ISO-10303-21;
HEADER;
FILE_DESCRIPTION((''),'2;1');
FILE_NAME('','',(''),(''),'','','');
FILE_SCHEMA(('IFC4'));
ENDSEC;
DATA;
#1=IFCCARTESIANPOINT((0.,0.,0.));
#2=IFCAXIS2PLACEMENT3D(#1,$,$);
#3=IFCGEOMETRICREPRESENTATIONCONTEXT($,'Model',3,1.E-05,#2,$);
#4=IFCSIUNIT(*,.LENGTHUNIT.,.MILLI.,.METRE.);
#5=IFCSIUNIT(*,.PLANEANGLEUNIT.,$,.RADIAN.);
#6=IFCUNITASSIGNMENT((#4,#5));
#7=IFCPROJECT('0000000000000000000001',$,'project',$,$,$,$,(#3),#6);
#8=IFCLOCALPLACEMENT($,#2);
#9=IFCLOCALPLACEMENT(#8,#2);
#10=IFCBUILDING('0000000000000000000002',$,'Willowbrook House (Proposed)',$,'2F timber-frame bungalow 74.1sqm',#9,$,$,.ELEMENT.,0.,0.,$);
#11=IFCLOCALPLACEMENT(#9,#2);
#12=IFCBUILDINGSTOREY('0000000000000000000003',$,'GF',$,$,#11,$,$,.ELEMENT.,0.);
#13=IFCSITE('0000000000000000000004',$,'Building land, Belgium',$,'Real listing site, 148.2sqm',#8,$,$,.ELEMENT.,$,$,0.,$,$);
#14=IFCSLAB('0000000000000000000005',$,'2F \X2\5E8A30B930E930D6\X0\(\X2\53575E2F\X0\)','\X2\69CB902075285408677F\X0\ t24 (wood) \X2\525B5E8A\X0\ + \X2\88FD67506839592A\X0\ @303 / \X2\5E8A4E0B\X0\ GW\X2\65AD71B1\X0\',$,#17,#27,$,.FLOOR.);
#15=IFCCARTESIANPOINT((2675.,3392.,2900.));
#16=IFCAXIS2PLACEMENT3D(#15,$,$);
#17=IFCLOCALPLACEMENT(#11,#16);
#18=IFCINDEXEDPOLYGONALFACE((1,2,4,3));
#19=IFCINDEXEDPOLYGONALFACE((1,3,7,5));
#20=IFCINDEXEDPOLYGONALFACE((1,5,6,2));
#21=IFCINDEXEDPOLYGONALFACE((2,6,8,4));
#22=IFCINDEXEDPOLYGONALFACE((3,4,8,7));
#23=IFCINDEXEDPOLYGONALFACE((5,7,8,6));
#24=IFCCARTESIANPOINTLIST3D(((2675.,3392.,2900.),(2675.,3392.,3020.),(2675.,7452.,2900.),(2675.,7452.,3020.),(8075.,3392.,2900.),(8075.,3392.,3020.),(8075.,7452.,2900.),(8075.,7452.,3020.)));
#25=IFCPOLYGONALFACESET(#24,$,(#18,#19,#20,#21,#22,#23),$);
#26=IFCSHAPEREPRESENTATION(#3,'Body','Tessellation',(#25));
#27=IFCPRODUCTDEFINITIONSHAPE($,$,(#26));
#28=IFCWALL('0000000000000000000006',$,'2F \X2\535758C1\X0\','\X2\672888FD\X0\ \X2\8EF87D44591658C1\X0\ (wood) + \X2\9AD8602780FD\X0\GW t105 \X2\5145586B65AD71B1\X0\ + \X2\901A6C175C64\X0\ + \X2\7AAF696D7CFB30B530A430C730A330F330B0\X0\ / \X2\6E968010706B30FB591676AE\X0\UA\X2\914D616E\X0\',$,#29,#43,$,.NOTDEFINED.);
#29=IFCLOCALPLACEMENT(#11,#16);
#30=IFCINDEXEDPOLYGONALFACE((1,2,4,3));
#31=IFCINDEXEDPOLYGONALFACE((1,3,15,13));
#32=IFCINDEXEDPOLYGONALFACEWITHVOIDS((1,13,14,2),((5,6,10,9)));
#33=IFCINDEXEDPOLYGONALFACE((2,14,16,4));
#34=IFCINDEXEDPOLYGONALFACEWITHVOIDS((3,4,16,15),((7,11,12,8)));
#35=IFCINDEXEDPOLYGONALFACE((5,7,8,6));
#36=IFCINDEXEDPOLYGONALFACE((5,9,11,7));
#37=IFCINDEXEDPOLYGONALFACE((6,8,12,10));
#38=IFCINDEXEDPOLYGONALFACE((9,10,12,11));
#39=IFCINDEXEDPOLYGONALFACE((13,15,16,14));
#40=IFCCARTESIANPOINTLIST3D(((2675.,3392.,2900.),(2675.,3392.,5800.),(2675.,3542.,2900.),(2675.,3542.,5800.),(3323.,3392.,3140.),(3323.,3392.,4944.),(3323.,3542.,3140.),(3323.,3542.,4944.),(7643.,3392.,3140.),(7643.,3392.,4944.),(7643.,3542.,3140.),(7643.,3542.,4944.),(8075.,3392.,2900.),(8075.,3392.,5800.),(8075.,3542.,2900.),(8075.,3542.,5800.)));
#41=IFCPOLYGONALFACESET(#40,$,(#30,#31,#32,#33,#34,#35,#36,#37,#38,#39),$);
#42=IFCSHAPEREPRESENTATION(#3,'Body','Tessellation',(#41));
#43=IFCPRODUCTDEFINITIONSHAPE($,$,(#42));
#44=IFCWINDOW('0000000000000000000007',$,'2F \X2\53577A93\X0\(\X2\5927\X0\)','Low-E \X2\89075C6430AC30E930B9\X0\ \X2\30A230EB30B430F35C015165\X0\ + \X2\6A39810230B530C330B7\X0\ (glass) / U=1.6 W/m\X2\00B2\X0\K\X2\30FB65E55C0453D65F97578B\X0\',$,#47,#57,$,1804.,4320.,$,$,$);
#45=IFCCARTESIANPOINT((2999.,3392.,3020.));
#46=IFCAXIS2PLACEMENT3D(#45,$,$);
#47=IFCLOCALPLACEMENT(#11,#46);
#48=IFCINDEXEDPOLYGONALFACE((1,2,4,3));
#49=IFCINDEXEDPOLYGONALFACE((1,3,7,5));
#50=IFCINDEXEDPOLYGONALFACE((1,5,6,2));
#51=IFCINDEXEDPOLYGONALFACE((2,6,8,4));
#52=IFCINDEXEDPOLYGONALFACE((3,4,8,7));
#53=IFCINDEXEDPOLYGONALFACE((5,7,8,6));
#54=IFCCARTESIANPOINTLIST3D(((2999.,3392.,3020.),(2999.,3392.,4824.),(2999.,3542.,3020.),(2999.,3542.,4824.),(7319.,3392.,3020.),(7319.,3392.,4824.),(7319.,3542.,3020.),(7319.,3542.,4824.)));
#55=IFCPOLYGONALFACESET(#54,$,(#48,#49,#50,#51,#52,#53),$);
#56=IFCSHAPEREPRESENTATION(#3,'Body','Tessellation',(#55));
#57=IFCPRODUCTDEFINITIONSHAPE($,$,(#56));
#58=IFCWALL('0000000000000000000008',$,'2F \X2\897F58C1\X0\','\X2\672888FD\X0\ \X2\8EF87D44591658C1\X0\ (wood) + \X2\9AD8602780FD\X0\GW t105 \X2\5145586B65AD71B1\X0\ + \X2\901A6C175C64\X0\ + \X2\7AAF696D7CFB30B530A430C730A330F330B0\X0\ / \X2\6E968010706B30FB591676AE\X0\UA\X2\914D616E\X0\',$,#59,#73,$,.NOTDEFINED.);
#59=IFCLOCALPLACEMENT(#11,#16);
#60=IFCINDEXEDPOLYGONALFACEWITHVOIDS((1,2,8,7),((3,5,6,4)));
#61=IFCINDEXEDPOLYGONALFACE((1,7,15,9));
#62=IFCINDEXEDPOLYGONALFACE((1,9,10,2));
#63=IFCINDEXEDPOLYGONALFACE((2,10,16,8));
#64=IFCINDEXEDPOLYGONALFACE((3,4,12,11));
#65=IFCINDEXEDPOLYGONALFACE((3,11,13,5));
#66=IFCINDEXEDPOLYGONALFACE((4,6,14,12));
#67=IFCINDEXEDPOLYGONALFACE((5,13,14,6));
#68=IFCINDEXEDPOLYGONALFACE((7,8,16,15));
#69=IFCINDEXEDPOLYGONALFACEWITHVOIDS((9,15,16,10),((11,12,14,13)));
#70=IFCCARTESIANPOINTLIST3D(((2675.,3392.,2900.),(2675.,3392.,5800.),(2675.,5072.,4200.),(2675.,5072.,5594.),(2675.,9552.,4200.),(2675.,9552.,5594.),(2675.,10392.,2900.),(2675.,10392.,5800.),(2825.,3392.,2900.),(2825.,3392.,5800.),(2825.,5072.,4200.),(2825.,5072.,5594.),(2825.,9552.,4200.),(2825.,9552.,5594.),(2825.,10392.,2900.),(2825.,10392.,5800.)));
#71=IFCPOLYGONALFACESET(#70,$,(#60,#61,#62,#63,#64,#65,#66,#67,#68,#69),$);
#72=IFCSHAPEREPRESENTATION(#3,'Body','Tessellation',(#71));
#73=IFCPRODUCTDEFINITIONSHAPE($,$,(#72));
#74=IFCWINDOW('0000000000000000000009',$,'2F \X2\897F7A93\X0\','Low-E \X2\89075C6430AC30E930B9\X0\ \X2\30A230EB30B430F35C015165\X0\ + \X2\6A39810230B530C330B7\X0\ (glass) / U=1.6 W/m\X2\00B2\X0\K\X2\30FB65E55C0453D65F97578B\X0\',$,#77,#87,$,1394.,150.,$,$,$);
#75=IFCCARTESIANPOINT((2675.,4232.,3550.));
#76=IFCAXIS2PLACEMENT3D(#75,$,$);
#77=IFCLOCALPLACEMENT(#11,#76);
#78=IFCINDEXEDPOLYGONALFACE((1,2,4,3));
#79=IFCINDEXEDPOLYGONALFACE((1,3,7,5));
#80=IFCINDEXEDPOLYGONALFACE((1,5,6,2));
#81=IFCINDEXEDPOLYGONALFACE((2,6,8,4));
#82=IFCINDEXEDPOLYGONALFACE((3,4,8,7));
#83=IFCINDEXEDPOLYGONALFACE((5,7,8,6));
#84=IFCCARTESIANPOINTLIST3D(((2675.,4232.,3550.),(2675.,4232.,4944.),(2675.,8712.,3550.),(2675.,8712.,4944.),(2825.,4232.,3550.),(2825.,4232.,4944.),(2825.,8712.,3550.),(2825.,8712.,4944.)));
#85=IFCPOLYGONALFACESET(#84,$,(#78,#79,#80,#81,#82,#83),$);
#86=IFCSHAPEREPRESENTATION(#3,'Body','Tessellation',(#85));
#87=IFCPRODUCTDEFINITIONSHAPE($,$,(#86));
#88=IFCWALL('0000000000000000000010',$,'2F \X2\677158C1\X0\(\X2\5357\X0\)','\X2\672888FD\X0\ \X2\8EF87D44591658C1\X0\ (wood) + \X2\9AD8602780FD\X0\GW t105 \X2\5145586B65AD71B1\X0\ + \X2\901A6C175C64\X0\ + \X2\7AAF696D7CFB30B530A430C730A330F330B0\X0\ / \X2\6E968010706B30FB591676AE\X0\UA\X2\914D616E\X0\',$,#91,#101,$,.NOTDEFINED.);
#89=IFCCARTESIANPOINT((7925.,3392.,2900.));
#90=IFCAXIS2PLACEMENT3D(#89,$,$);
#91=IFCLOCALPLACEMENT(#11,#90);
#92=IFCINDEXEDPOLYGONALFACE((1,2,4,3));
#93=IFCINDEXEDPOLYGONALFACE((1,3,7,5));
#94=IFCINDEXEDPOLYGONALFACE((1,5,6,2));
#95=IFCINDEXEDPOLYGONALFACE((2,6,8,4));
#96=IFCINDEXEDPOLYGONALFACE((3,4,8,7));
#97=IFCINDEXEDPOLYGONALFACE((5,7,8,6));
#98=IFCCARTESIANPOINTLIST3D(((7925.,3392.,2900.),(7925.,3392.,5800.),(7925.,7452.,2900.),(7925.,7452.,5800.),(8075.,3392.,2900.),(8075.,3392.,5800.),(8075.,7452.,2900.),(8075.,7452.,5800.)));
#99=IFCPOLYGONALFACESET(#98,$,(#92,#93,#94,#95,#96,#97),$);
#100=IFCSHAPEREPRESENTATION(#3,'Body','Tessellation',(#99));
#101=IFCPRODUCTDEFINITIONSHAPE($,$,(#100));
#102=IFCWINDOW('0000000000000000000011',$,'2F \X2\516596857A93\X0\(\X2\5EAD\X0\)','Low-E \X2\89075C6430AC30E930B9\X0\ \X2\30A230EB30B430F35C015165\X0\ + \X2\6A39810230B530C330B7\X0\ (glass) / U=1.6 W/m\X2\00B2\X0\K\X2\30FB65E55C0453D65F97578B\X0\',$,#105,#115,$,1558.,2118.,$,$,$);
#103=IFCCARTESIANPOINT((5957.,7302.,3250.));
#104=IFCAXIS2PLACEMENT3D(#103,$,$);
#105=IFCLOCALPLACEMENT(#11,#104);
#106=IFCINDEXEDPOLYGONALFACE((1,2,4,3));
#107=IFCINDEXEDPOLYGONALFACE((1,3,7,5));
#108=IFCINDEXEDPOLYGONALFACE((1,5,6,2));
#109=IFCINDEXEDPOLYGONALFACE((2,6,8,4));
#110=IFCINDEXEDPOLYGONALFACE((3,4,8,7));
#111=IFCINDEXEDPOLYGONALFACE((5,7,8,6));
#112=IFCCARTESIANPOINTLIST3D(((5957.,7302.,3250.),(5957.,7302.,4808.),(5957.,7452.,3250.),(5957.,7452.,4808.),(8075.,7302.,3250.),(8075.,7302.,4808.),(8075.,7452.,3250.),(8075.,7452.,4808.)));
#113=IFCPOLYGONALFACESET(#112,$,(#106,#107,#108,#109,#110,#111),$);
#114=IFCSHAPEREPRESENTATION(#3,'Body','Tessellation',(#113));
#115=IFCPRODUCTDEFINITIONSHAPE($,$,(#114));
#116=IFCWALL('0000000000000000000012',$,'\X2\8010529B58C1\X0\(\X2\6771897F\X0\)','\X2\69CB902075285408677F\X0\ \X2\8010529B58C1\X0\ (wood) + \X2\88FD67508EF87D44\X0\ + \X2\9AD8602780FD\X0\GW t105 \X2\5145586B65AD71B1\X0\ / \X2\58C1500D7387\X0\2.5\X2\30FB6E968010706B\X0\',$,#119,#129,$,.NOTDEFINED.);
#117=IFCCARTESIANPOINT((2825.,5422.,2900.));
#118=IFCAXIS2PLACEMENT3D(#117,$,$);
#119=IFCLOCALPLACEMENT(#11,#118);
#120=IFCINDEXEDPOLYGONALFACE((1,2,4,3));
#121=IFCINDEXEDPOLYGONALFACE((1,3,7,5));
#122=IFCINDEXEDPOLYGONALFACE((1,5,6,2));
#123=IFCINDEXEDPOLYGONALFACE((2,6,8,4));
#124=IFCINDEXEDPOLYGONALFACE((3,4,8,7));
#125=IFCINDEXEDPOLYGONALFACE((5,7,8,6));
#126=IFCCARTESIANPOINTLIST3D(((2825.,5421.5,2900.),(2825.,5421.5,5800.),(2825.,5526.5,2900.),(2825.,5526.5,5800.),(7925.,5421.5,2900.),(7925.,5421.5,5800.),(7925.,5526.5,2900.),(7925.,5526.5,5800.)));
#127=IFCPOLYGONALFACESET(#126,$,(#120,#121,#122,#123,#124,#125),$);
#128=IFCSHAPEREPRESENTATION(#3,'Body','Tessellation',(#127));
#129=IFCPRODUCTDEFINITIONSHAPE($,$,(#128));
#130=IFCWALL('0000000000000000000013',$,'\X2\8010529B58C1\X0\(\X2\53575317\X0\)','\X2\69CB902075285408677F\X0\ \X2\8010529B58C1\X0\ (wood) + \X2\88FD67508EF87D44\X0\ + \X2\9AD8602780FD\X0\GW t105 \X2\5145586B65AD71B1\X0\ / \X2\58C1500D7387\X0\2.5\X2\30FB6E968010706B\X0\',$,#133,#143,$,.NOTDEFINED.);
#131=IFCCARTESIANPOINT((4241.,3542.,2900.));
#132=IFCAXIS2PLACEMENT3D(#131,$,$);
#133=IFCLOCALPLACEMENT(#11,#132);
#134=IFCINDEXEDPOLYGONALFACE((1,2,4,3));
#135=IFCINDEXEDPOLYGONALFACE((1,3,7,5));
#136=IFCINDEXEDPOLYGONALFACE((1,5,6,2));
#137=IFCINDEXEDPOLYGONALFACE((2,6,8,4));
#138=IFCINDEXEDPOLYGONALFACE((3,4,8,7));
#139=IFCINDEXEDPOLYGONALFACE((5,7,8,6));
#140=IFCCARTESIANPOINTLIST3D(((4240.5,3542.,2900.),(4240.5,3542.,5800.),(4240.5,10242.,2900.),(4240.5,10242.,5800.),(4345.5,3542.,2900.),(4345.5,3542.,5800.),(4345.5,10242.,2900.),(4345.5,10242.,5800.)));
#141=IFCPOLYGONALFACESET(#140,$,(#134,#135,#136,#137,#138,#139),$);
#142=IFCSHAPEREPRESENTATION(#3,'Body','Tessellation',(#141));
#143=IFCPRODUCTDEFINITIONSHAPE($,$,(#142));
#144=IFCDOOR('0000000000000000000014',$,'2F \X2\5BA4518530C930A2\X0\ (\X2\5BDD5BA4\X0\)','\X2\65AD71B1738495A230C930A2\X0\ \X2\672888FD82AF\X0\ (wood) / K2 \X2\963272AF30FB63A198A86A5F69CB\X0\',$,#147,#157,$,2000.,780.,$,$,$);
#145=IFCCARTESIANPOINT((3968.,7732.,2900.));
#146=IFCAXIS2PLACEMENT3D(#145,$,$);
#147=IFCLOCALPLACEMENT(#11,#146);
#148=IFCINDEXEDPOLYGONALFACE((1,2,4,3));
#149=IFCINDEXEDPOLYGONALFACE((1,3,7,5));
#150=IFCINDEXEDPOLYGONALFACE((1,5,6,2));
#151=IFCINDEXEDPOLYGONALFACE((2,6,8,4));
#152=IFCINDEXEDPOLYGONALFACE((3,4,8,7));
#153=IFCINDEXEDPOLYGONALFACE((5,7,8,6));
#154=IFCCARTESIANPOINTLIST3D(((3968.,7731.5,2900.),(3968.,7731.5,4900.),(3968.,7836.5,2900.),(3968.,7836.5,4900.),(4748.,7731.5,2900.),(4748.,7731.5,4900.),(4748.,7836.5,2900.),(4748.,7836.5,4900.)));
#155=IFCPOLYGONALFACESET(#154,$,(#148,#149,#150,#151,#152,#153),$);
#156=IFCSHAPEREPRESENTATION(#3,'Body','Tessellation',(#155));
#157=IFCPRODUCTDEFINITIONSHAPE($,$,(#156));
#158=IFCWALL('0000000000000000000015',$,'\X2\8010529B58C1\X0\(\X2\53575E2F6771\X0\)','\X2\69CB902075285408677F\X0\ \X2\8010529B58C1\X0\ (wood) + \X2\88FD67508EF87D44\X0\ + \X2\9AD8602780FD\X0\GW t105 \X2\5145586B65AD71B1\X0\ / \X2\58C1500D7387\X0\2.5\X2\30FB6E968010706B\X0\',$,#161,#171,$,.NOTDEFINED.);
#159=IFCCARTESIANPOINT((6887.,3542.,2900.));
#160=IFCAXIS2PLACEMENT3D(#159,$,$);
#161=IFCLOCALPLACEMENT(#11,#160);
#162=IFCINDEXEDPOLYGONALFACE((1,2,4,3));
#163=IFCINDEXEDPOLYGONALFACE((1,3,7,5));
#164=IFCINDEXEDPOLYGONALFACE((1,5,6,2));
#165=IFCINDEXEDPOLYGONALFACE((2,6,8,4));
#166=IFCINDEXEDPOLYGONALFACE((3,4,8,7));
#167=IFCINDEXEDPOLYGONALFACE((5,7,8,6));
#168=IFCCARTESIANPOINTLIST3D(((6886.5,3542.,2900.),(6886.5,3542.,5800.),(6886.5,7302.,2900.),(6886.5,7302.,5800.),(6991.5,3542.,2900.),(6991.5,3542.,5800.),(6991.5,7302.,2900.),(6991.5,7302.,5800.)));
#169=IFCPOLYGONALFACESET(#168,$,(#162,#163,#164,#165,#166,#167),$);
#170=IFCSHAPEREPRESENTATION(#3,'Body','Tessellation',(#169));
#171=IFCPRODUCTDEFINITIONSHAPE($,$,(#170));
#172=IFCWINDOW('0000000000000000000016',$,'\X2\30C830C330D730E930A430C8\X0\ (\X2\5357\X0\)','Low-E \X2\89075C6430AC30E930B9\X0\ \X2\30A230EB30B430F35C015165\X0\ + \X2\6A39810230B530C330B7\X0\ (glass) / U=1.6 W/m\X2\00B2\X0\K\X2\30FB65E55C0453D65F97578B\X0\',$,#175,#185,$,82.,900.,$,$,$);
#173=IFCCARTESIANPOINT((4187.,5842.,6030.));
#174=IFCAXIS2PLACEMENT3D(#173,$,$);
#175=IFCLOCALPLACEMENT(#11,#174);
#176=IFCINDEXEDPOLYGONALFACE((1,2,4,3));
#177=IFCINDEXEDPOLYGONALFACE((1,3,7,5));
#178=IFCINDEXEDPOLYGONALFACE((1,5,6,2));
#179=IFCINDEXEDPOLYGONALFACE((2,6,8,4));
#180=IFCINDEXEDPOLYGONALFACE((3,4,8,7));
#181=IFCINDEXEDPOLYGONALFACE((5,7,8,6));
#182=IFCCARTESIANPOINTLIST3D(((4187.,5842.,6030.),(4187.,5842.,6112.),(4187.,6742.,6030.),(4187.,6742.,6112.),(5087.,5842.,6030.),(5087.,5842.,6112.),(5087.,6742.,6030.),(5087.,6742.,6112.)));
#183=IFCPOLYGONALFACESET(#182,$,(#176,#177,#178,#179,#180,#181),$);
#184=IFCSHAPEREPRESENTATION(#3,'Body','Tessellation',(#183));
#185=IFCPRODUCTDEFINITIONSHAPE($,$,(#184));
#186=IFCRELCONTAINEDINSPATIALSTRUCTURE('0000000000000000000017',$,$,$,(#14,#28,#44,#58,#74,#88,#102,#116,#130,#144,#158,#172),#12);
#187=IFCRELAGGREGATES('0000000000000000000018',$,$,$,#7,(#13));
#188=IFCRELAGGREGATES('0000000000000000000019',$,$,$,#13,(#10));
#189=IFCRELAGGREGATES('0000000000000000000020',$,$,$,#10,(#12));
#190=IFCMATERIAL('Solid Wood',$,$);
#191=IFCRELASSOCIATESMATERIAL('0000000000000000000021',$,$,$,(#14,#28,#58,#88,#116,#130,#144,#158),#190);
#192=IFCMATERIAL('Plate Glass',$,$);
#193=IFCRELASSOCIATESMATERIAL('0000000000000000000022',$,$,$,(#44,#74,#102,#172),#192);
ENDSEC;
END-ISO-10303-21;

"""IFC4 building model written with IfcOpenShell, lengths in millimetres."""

from ifc_helpers import new_model, si_unit, frame, frame_2d, origin, place, context, project, spatial, rectangle, extrude, material, element, fill, save


model = new_model("IFC4")

# Units and contexts
model_context = context("Model", 3, precision=1e-05, world=origin())
ifc_project = project(units=[si_unit("LENGTHUNIT", "METRE", prefix="MILLI"), si_unit("PLANEANGLEUNIT", "RADIAN")], contexts=[model_context])

# Site, building, storey
site_placement = place(None, origin())
site = spatial("IfcSite", under=ifc_project, at=site_placement, Name="Building land, Belgium", ObjectType="Real listing site, 148.2sqm", CompositionType="ELEMENT", RefElevation=0.0)
building_placement = place(site_placement, origin())
building = spatial("IfcBuilding", under=site, at=building_placement, Name="Willowbrook House (Proposed)", ObjectType="2F timber-frame bungalow 74.1sqm", CompositionType="ELEMENT", ElevationOfRefHeight=0.0, ElevationOfTerrain=0.0)
storey_placement = place(building_placement, origin())
storey = spatial("IfcBuildingStorey", under=building, at=storey_placement, Name="GF", CompositionType="ELEMENT", Elevation=0.0)

# Slab
ifc_material_1 = material(Name="Solid Wood")
slab_placement = place(storey_placement, frame((2675.0, 3392.0, 2900.0)))
element("IfcSlab", 1, at=slab_placement, inside=storey, material=ifc_material_1, Name="2F 床スラブ(南帯)", Description="構造用合板 t24 (wood) 剛床 + 製材根太 @303 / 床下 GW断熱", PredefinedType="FLOOR", context=model_context, shape_type="SweptSolid", body=[
    extrude(rectangle(XDim=5400.0, YDim=4060.0, at=frame_2d((2700.0, 2030.0))), frame((2675.0, 3392.0, 2900.0)), (0.0, 0.0, 1.0), 120.0),
])

# Walls, openings, windows
wall_1_placement = place(storey_placement, frame((2675.0, 3392.0, 2900.0)))
wall_1 = element("IfcWall", 2, at=wall_1_placement, inside=storey, material=ifc_material_1, Name="2F 南壁", Description="木製 軸組外壁 (wood) + 高性能GW t105 充填断熱 + 通気層 + 窯業系サイディング / 準耐火・外皮UA配慮", PredefinedType="NOTDEFINED", context=model_context, shape_type="SweptSolid", body=[
    extrude(rectangle(XDim=5400.0, YDim=150.0, at=frame_2d((2700.0, 75.0))), frame((2675.0, 3392.0, 2900.0)), (0.0, 0.0, 1.0), 2900.0),
])
opening_1_placement = place(storey_placement, frame((2999.0, 3392.0, 3020.0)))
opening_1 = element("IfcOpeningElement", 3, at=opening_1_placement, cuts=wall_1, PredefinedType="NOTDEFINED", context=model_context, shape_type="SweptSolid", body=[
    extrude(rectangle(XDim=4320.0, YDim=150.0, at=frame_2d((2160.0, 75.0))), frame((2999.0, 3392.0, 3020.0)), (0.0, 0.0, 1.0), 1804.0),
])
ifc_material_2 = material(Name="Plate Glass")
window_1_placement = place(storey_placement, frame((2999.0, 3392.0, 3020.0)))
window_1 = element("IfcWindow", 4, at=window_1_placement, inside=storey, material=ifc_material_2, Name="2F 南窓(大)", Description="Low-E 複層ガラス アルゴン封入 + 樹脂サッシ (glass) / U=1.6 W/m²K・日射取得型", OverallHeight=1804.0, OverallWidth=4320.0, context=model_context, shape_type="SweptSolid", body=[
    extrude(rectangle(XDim=4320.0, YDim=150.0, at=frame_2d((2160.0, 75.0))), frame((2999.0, 3392.0, 3020.0)), (0.0, 0.0, 1.0), 1804.0),
])
fill(opening_1, window_1)
wall_2_placement = place(storey_placement, frame((2675.0, 3392.0, 2900.0)))
wall_2 = element("IfcWall", 5, at=wall_2_placement, inside=storey, material=ifc_material_1, Name="2F 西壁", Description="木製 軸組外壁 (wood) + 高性能GW t105 充填断熱 + 通気層 + 窯業系サイディング / 準耐火・外皮UA配慮", PredefinedType="NOTDEFINED", context=model_context, shape_type="SweptSolid", body=[
    extrude(rectangle(XDim=150.0, YDim=7000.0, at=frame_2d((75.0, 3500.0))), frame((2675.0, 3392.0, 2900.0)), (0.0, 0.0, 1.0), 2900.0),
])
opening_2_placement = place(storey_placement, frame((2675.0, 4232.0, 3550.0)))
opening_2 = element("IfcOpeningElement", 6, at=opening_2_placement, cuts=wall_2, PredefinedType="NOTDEFINED", context=model_context, shape_type="SweptSolid", body=[
    extrude(rectangle(XDim=150.0, YDim=4480.0, at=frame_2d((75.0, 2240.0))), frame((2675.0, 4232.0, 3550.0)), (0.0, 0.0, 1.0), 1394.0),
])
window_2_placement = place(storey_placement, frame((2675.0, 4232.0, 3550.0)))
window_2 = element("IfcWindow", 7, at=window_2_placement, inside=storey, material=ifc_material_2, Name="2F 西窓", Description="Low-E 複層ガラス アルゴン封入 + 樹脂サッシ (glass) / U=1.6 W/m²K・日射取得型", OverallHeight=1394.0, OverallWidth=150.0, context=model_context, shape_type="SweptSolid", body=[
    extrude(rectangle(XDim=150.0, YDim=4480.0, at=frame_2d((75.0, 2240.0))), frame((2675.0, 4232.0, 3550.0)), (0.0, 0.0, 1.0), 1394.0),
])
fill(opening_2, window_2)
wall_3_placement = place(storey_placement, frame((7925.0, 3392.0, 2900.0)))
wall_3 = element("IfcWall", 8, at=wall_3_placement, inside=storey, material=ifc_material_1, Name="2F 東壁(南)", Description="木製 軸組外壁 (wood) + 高性能GW t105 充填断熱 + 通気層 + 窯業系サイディング / 準耐火・外皮UA配慮", PredefinedType="NOTDEFINED", context=model_context, shape_type="SweptSolid", body=[
    extrude(rectangle(XDim=150.0, YDim=4060.0, at=frame_2d((75.0, 2030.0))), frame((7925.0, 3392.0, 2900.0)), (0.0, 0.0, 1.0), 2900.0),
])
opening_3_placement = place(storey_placement, frame((5957.0, 7302.0, 3250.0)))
opening_3 = element("IfcOpeningElement", 9, at=opening_3_placement, cuts=wall_3, PredefinedType="NOTDEFINED", context=model_context, shape_type="SweptSolid", body=[
    extrude(rectangle(XDim=2118.0, YDim=150.0, at=frame_2d((1059.0, 75.0))), frame((5957.0, 7302.0, 3250.0)), (0.0, 0.0, 1.0), 1558.0),
])
window_3_placement = place(storey_placement, frame((5957.0, 7302.0, 3250.0)))
window_3 = element("IfcWindow", 10, at=window_3_placement, inside=storey, material=ifc_material_2, Name="2F 入隅窓(庭)", Description="Low-E 複層ガラス アルゴン封入 + 樹脂サッシ (glass) / U=1.6 W/m²K・日射取得型", OverallHeight=1558.0, OverallWidth=2118.0, context=model_context, shape_type="SweptSolid", body=[
    extrude(rectangle(XDim=2118.0, YDim=150.0, at=frame_2d((1059.0, 75.0))), frame((5957.0, 7302.0, 3250.0)), (0.0, 0.0, 1.0), 1558.0),
])
fill(opening_3, window_3)

# Wall
wall_4_placement = place(storey_placement, frame((2825.0, 5422.0, 2900.0)))
element("IfcWall", 11, at=wall_4_placement, inside=storey, material=ifc_material_1, Name="耐力壁(東西)", Description="構造用合板 耐力壁 (wood) + 製材軸組 + 高性能GW t105 充填断熱 / 壁倍率2.5・準耐火", PredefinedType="NOTDEFINED", context=model_context, shape_type="SweptSolid", body=[
    extrude(rectangle(XDim=5100.0, YDim=105.0, at=frame_2d((2550.0, 52.0))), frame((2825.0, 5422.0, 2900.0)), (0.0, 0.0, 1.0), 2900.0),
])

# Wall, opening, door
wall_5_placement = place(storey_placement, frame((4241.0, 3542.0, 2900.0)))
wall_5 = element("IfcWall", 12, at=wall_5_placement, inside=storey, material=ifc_material_1, Name="耐力壁(南北)", Description="構造用合板 耐力壁 (wood) + 製材軸組 + 高性能GW t105 充填断熱 / 壁倍率2.5・準耐火", PredefinedType="NOTDEFINED", context=model_context, shape_type="SweptSolid", body=[
    extrude(rectangle(XDim=105.0, YDim=6700.0, at=frame_2d((52.0, 3350.0))), frame((4241.0, 3542.0, 2900.0)), (0.0, 0.0, 1.0), 2900.0),
])
opening_4_placement = place(storey_placement, frame((3968.0, 7732.0, 2900.0)))
opening_4 = element("IfcOpeningElement", 13, at=opening_4_placement, cuts=wall_5, PredefinedType="NOTDEFINED", context=model_context, shape_type="SweptSolid", body=[
    extrude(rectangle(XDim=780.0, YDim=105.0, at=frame_2d((390.0, 52.0))), frame((3968.0, 7732.0, 2900.0)), (0.0, 0.0, 1.0), 2000.0),
])
door_placement = place(storey_placement, frame((3968.0, 7732.0, 2900.0)))
door = element("IfcDoor", 14, at=door_placement, inside=storey, material=ifc_material_1, Name="2F 室内ドア (寝室)", Description="断熱玄関ドア 木製芯 (wood) / K2 防犯・採風機構", OverallHeight=2000.0, OverallWidth=780.0, context=model_context, shape_type="SweptSolid", body=[
    extrude(rectangle(XDim=780.0, YDim=105.0, at=frame_2d((390.0, 52.0))), frame((3968.0, 7732.0, 2900.0)), (0.0, 0.0, 1.0), 2000.0),
])
fill(opening_4, door)

# Wall
wall_6_placement = place(storey_placement, frame((6887.0, 3542.0, 2900.0)))
element("IfcWall", 15, at=wall_6_placement, inside=storey, material=ifc_material_1, Name="耐力壁(南帯東)", Description="構造用合板 耐力壁 (wood) + 製材軸組 + 高性能GW t105 充填断熱 / 壁倍率2.5・準耐火", PredefinedType="NOTDEFINED", context=model_context, shape_type="SweptSolid", body=[
    extrude(rectangle(XDim=105.0, YDim=3760.0, at=frame_2d((52.0, 1880.0))), frame((6887.0, 3542.0, 2900.0)), (0.0, 0.0, 1.0), 2900.0),
])

# Window
window_4_placement = place(storey_placement, frame((4187.0, 5842.0, 6030.0)))
element("IfcWindow", 16, at=window_4_placement, inside=storey, material=ifc_material_2, Name="トップライト (南)", Description="Low-E 複層ガラス アルゴン封入 + 樹脂サッシ (glass) / U=1.6 W/m²K・日射取得型", OverallHeight=82.0, OverallWidth=900.0, context=model_context, shape_type="SweptSolid", body=[
    extrude(rectangle(XDim=900.0, YDim=900.0, at=frame_2d((450.0, 450.0))), frame((4187.0, 5842.0, 6030.0)), (0.0, 0.0, 1.0), 82.0),
])

save(model, "model.ifc")
